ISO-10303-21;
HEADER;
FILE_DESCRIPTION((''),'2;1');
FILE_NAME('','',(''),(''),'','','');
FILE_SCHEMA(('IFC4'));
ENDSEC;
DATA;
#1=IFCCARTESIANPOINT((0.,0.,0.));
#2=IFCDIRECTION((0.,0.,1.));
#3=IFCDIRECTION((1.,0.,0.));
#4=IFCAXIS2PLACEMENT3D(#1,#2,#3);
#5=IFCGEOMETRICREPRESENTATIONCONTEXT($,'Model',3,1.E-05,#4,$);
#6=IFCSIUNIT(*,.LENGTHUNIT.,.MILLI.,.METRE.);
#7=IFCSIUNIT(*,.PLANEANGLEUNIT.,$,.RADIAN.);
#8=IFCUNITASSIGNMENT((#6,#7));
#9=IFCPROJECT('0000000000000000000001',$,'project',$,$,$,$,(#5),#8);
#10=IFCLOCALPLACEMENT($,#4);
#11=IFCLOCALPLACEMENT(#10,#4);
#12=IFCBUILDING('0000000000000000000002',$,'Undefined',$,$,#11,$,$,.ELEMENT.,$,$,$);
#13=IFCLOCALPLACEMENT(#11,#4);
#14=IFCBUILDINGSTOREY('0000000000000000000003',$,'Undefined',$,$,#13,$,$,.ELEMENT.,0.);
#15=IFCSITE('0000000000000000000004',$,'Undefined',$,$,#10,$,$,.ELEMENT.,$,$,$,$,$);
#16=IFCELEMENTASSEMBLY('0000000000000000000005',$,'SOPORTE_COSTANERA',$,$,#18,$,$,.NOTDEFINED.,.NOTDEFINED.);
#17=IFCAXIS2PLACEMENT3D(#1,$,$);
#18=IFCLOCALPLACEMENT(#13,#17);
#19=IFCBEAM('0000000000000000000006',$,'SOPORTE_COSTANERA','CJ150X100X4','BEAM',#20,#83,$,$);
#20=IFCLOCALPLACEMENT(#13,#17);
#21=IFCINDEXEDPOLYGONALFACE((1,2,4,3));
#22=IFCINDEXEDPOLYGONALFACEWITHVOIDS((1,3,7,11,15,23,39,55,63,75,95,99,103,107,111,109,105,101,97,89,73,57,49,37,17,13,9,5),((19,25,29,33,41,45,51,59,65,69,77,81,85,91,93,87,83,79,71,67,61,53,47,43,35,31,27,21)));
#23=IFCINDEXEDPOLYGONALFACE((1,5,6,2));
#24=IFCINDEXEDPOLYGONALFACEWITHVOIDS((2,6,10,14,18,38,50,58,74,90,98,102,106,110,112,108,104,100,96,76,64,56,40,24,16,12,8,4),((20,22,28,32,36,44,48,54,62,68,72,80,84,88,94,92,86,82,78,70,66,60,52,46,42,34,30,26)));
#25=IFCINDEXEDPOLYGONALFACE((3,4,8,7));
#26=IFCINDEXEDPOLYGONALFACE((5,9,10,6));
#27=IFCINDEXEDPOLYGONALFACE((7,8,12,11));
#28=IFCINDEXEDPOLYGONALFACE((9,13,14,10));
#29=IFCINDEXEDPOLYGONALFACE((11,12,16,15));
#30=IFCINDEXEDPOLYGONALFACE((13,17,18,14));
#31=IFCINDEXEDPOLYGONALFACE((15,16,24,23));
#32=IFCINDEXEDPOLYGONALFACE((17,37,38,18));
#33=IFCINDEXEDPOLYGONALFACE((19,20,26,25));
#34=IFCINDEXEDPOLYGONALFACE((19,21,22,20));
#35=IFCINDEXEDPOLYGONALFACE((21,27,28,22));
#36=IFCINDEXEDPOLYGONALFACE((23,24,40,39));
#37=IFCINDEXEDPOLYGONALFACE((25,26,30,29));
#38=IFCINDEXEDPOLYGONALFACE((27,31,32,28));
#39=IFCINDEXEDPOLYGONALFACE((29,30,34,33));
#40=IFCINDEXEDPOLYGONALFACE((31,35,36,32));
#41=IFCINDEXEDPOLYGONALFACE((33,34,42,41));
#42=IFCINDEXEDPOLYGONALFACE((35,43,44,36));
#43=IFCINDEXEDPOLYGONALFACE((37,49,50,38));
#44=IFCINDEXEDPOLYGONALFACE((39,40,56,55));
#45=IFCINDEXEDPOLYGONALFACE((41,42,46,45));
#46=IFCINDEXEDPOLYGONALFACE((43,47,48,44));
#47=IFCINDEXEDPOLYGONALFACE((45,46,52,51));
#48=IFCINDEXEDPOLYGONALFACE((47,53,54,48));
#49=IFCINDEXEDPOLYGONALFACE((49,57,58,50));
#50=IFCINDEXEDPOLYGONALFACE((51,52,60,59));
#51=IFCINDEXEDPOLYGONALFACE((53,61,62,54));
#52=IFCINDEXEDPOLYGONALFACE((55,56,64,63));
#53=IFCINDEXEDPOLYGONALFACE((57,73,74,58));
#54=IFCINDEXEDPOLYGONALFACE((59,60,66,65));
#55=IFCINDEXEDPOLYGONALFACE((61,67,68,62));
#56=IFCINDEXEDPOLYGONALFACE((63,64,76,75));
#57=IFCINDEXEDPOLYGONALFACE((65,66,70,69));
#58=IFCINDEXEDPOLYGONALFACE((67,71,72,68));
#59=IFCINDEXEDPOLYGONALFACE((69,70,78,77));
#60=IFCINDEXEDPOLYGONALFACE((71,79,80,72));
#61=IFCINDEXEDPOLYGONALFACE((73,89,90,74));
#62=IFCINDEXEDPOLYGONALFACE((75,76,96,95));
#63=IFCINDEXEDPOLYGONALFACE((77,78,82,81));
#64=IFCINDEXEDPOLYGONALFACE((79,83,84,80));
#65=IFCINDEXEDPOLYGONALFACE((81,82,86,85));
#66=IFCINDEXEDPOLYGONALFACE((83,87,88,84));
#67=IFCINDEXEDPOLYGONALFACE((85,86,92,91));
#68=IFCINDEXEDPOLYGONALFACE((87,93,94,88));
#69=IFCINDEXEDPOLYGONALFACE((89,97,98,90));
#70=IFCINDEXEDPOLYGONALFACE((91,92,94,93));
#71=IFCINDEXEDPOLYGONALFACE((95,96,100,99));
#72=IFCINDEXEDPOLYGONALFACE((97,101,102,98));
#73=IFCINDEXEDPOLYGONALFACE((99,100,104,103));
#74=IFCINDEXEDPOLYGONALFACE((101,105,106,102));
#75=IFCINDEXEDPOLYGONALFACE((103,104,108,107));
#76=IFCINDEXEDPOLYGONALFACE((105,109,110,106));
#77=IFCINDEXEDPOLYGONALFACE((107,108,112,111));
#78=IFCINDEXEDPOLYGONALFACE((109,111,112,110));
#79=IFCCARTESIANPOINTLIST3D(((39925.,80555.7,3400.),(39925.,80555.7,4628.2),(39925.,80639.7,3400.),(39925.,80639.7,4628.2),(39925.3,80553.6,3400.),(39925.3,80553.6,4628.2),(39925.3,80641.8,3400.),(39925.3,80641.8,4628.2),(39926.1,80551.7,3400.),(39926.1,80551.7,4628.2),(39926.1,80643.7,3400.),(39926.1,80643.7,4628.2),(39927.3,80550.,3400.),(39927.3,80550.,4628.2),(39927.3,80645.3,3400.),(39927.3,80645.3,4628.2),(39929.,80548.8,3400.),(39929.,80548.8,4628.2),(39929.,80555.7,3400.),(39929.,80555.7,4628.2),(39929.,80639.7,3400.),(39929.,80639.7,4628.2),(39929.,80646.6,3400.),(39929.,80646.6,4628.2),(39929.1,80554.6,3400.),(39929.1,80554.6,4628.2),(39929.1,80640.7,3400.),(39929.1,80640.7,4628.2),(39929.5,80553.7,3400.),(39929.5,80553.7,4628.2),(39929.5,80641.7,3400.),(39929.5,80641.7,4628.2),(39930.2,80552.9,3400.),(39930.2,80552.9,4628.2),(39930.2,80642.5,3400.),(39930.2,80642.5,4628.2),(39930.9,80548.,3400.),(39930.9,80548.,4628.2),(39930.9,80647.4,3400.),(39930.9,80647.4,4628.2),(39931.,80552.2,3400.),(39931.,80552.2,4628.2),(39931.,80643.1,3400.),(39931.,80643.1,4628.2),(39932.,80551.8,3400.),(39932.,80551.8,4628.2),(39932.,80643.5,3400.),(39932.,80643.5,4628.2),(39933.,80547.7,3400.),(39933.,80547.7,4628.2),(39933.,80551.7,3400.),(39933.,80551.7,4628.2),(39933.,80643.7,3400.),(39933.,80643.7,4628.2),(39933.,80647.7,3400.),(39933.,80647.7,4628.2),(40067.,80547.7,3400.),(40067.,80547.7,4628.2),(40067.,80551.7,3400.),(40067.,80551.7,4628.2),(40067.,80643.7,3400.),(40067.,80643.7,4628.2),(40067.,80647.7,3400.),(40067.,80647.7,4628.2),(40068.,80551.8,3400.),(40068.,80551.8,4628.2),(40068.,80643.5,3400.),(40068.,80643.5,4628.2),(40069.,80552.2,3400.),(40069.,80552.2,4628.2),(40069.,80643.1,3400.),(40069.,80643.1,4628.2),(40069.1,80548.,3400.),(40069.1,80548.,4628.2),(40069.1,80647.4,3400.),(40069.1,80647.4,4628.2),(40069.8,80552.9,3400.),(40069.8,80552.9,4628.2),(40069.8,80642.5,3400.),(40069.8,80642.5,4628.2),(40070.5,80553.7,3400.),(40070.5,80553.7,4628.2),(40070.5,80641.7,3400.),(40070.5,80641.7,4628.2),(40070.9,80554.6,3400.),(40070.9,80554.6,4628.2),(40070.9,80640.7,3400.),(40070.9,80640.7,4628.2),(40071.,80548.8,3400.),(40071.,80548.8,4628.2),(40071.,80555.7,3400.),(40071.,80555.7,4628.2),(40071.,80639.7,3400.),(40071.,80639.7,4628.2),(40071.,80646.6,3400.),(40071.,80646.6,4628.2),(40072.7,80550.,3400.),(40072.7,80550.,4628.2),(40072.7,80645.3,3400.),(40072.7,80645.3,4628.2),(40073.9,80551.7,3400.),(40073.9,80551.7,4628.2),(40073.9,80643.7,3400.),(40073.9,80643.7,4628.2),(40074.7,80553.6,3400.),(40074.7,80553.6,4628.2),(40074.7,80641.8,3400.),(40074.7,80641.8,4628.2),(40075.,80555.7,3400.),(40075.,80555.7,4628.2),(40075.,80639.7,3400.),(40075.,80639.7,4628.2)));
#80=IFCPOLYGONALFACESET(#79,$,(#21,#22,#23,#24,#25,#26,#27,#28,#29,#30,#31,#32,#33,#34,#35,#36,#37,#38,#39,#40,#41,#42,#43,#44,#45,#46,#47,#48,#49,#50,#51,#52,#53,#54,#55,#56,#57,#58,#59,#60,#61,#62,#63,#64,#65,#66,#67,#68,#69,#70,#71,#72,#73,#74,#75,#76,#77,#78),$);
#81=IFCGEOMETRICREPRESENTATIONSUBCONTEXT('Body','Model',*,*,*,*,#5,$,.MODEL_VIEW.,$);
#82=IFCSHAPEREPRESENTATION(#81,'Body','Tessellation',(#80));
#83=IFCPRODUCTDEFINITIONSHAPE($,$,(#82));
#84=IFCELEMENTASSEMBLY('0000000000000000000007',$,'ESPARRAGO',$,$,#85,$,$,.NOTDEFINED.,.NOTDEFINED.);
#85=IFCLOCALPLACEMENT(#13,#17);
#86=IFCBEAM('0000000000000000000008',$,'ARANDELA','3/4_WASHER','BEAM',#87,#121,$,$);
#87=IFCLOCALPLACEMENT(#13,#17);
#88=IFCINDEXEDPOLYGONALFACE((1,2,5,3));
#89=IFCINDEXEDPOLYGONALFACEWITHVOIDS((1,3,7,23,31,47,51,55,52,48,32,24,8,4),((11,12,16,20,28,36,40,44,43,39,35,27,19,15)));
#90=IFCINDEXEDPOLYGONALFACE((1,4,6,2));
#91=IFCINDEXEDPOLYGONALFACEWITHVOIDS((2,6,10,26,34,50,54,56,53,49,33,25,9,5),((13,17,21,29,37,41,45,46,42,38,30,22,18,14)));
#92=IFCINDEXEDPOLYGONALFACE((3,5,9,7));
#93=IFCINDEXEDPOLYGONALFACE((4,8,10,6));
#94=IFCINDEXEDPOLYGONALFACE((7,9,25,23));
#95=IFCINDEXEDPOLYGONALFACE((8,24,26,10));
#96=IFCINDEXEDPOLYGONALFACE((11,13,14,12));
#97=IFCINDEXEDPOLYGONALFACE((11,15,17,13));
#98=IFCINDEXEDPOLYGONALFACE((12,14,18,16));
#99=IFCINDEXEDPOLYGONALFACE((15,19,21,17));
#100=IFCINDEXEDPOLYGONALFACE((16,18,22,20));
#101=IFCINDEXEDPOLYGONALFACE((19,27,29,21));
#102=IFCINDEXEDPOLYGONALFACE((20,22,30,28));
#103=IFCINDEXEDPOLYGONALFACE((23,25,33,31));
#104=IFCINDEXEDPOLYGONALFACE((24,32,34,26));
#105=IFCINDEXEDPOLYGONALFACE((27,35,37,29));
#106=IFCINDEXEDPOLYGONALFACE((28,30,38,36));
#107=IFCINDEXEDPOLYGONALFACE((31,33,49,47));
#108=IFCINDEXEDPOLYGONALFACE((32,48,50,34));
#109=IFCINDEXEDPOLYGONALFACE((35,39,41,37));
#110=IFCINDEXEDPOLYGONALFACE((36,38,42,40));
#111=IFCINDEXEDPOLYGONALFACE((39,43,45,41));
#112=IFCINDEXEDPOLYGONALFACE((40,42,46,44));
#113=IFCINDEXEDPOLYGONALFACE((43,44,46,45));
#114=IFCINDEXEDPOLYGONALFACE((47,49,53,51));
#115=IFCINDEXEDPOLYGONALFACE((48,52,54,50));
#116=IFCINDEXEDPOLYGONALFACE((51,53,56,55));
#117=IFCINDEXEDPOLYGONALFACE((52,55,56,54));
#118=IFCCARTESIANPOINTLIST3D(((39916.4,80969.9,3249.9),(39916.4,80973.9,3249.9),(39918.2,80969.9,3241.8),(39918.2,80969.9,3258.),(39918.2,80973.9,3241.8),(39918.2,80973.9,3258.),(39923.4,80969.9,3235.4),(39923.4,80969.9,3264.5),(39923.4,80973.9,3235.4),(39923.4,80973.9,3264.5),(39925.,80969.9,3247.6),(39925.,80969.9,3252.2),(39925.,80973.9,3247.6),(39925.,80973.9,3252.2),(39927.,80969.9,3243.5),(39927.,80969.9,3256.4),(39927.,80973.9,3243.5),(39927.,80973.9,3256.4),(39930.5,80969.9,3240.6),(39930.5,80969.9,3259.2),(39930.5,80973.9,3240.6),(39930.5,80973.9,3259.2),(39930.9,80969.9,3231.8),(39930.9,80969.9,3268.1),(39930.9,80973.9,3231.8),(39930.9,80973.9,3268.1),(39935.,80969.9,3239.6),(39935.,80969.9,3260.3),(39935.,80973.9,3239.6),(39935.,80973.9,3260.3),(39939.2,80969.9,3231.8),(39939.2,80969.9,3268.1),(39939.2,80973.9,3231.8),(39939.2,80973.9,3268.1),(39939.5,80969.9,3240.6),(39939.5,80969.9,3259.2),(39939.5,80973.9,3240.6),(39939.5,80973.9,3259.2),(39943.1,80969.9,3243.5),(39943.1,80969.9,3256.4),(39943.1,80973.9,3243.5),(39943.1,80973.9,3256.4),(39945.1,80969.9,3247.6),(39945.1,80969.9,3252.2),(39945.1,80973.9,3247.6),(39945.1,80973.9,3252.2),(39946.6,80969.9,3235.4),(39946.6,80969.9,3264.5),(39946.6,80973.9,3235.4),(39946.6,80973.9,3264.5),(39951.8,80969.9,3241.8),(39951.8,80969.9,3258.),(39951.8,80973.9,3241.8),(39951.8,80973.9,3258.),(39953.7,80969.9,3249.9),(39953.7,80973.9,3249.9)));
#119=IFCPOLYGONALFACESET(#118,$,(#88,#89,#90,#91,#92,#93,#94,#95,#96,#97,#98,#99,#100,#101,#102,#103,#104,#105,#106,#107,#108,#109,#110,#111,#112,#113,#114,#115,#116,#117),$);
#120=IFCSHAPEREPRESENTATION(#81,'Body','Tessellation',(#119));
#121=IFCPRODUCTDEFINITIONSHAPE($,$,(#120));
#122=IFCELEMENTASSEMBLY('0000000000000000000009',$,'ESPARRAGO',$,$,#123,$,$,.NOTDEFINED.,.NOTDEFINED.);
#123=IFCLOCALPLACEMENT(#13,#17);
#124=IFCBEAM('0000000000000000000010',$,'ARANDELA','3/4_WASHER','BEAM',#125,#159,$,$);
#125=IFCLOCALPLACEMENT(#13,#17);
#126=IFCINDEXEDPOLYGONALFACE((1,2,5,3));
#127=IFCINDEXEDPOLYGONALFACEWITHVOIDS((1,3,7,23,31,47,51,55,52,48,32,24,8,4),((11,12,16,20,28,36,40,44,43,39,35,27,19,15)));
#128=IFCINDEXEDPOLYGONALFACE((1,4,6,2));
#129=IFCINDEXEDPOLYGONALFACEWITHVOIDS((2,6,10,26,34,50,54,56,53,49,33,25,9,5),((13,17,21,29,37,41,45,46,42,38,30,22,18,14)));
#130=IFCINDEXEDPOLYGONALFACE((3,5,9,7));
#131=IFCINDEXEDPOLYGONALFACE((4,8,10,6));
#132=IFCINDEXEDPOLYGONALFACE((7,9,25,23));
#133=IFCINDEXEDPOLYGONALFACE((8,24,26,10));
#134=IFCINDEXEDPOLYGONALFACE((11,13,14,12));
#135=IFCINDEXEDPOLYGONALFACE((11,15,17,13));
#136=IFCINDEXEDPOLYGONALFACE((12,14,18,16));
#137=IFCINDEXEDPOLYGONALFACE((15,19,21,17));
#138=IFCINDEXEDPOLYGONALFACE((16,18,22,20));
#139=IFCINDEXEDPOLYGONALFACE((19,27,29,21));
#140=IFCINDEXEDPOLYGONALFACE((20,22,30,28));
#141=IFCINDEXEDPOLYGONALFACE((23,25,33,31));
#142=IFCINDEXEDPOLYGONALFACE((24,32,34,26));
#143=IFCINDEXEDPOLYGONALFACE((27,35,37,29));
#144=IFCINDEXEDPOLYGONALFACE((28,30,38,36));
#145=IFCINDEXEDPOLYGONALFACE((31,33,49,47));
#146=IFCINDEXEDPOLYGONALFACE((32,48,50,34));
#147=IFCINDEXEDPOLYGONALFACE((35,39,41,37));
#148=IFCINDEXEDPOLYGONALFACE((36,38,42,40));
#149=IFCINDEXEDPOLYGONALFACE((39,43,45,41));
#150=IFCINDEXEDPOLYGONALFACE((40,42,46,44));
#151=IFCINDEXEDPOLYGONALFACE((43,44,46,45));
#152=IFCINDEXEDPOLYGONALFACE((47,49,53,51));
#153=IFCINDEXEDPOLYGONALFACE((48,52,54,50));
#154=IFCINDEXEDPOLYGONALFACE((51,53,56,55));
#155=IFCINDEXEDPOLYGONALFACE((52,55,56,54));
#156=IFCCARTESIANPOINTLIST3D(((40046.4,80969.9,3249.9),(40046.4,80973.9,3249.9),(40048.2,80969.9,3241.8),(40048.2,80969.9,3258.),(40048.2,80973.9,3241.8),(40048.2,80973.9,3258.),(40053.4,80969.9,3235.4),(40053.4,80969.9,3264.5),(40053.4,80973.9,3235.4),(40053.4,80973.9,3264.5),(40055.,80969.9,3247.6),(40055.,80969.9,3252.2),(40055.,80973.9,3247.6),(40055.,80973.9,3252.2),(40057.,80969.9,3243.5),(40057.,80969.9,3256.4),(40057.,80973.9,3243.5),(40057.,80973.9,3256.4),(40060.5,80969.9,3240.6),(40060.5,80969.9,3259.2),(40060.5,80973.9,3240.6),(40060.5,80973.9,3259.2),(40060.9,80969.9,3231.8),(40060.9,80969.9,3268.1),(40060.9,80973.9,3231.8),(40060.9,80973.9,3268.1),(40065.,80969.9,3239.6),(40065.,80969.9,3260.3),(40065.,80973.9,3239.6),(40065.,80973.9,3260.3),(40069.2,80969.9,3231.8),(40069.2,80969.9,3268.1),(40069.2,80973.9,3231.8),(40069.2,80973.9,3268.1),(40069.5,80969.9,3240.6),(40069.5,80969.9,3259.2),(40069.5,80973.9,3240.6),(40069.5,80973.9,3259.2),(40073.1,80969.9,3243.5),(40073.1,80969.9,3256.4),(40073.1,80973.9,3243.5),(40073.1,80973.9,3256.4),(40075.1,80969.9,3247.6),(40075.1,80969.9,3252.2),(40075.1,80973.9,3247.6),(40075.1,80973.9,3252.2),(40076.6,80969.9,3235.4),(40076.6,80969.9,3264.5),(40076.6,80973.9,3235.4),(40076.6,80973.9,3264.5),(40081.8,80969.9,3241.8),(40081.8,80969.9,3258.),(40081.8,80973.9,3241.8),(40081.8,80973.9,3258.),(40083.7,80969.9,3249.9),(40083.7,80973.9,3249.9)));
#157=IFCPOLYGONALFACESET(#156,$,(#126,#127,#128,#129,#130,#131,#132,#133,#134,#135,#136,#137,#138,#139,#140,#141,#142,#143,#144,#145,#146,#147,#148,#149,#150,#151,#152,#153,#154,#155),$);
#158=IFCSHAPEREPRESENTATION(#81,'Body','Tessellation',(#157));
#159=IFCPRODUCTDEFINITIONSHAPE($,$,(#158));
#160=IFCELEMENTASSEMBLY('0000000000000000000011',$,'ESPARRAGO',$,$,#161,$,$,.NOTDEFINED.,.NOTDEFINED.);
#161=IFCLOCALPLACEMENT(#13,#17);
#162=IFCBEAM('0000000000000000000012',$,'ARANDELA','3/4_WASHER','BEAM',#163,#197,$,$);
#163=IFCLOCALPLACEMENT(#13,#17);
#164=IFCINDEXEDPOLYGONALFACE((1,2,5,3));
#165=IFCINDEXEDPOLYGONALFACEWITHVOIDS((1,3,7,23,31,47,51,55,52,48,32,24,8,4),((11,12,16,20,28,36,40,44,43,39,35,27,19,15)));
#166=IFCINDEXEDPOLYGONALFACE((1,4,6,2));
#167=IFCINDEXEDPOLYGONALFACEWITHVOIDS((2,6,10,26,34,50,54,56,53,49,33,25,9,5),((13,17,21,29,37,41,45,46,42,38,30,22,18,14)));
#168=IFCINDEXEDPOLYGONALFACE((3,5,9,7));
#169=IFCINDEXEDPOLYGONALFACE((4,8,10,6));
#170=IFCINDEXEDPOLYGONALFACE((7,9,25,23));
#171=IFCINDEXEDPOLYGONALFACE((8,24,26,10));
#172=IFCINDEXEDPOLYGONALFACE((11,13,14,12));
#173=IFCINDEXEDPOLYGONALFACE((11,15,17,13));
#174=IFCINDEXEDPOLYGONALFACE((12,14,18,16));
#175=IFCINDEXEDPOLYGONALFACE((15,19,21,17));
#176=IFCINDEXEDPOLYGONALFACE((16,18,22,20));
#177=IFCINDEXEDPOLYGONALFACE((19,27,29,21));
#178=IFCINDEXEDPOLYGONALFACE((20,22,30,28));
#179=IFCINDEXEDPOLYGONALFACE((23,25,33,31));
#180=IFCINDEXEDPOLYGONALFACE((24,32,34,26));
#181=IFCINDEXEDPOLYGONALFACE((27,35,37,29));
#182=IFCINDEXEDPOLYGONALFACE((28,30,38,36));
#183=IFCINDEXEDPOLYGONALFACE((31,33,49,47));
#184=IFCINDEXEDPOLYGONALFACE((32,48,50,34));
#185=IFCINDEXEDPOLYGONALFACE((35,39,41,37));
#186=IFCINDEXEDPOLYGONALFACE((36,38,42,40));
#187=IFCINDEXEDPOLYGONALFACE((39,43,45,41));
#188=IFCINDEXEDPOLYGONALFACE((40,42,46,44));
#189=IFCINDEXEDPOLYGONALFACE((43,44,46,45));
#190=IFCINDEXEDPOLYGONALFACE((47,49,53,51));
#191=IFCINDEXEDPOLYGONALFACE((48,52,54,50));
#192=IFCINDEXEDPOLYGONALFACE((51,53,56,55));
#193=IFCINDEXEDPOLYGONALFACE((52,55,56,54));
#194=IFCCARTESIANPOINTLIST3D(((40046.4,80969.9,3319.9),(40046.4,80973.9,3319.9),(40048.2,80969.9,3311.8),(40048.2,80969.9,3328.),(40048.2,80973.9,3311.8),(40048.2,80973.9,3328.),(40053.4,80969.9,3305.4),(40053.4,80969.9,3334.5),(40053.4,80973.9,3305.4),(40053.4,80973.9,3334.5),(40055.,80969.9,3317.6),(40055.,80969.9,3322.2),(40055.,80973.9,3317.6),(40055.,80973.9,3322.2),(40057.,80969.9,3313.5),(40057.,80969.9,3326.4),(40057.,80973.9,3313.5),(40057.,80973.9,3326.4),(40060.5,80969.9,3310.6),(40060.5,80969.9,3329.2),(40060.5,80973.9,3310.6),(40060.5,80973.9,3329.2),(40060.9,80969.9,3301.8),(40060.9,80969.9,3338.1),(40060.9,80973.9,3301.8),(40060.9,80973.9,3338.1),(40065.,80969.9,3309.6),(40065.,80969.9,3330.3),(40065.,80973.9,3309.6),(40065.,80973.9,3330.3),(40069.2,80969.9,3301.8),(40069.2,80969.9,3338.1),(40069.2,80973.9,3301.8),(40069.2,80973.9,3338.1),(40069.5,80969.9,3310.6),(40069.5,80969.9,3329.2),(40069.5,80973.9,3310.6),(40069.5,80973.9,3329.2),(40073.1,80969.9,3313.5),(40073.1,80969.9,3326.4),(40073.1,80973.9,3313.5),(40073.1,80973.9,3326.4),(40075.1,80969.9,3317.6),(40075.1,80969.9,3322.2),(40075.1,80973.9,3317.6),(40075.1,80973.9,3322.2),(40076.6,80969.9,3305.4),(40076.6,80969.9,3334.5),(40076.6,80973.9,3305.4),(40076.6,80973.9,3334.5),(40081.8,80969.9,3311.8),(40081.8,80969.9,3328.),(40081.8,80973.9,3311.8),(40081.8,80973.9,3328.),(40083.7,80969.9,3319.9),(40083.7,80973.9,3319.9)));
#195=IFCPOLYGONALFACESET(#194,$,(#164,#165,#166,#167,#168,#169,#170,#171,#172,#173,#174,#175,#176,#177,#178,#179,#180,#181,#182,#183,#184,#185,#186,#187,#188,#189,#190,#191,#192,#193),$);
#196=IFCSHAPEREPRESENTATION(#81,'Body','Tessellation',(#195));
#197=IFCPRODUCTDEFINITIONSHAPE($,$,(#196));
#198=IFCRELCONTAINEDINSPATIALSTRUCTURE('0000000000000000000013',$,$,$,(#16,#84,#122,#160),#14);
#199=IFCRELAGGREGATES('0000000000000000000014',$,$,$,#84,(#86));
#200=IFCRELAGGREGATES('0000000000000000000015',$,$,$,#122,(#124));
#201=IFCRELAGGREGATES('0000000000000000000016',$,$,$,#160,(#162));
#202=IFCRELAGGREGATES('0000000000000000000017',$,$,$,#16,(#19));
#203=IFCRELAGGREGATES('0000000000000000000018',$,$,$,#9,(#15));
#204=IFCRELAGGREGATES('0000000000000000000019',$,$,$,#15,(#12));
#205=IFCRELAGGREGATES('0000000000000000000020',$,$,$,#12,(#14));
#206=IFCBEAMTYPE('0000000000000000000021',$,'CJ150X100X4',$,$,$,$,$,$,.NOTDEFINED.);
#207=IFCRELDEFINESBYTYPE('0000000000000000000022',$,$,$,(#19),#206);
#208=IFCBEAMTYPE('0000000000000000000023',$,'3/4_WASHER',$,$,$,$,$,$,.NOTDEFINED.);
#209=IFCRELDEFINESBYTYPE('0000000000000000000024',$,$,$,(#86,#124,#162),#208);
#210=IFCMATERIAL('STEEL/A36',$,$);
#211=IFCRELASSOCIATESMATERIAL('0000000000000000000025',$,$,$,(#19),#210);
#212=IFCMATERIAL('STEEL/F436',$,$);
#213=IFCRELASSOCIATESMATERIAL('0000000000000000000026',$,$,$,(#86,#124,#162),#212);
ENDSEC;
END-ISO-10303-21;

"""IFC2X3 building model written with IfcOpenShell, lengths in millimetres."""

from ifc_helpers import new_model, si_unit, frame, origin_with_axes, origin_2d_with_axis, place, context, subcontext, project, spatial, polyline, hollow_rectangle, outline, extrude, material, type_object, element, aggregate, save


model = new_model("IFC2X3")

# Units and contexts
model_context = context("Model", 3, precision=1e-05, world=origin_with_axes())
body_context = subcontext(model_context, "Body", "Model", "MODEL_VIEW")
ifc_project = project(units=[si_unit("LENGTHUNIT", "METRE", prefix="MILLI"), si_unit("PLANEANGLEUNIT", "RADIAN")], contexts=[model_context])

# Site, building, storey
site_placement = place(None, origin_with_axes())
site = spatial("IfcSite", under=ifc_project, at=site_placement, Name="Undefined", CompositionType="ELEMENT")
building_placement = place(site_placement, origin_with_axes())
building = spatial("IfcBuilding", under=site, at=building_placement, Name="Undefined", CompositionType="ELEMENT")
storey_placement = place(building_placement, origin_with_axes())
storey = spatial("IfcBuildingStorey", under=building, at=storey_placement, Name="Undefined", CompositionType="ELEMENT", Elevation=0.0)

# Element assemblies, beams
assembly_1_placement = place(storey_placement, origin_with_axes())
assembly_1 = element("IfcElementAssembly", 1, at=assembly_1_placement, inside=storey, Name="SOPORTE_COSTANERA", AssemblyPlace="NOTDEFINED", PredefinedType="NOTDEFINED")
ifc_material_1 = material(Name="STEEL/A36")
beam_type_1 = type_object("IfcBeamType", Name="CJ150X100X4", PredefinedType="NOTDEFINED")
beam_1_placement = place(assembly_1_placement, frame((40000.0, 80597.7, 4628.2), z_axis=(-1.0, 0.0, 0.0), x_axis=(0.0, 0.0, -1.0)))
beam_1 = element("IfcBeam", 2, at=beam_1_placement, type_object=beam_type_1, material=ifc_material_1, Name="SOPORTE_COSTANERA", Description="CJ150X100X4", ObjectType="BEAM", context=body_context, shape_type="SweptSolid", body=[
    extrude(hollow_rectangle(XDim=100.0, YDim=150.0, WallThickness=4.0, InnerFilletRadius=4.0, OuterFilletRadius=8.0, at=origin_2d_with_axis()), frame((1228.2, 0.0, 0.0), z_axis=(-1.0, 0.0, 0.0), x_axis=(0.0, -1.0, 0.0)), (0.0, 0.0, 1.0), 1228.2),
])
assembly_2_placement = place(storey_placement, origin_with_axes())
assembly_2 = element("IfcElementAssembly", 3, at=assembly_2_placement, inside=storey, Name="ESPARRAGO", AssemblyPlace="NOTDEFINED", PredefinedType="NOTDEFINED")
ifc_material_2 = material(Name="STEEL/F436")
beam_type_2 = type_object("IfcBeamType", Name="3/4_WASHER", PredefinedType="NOTDEFINED")
beam_2_placement = place(assembly_2_placement, frame((39935.0, 80969.9, 3249.9), z_axis=(0.0, 0.000086, 1.0), x_axis=(0.000015, 1.0, -0.000086)))
beam_2 = element("IfcBeam", 4, at=beam_2_placement, type_object=beam_type_2, material=ifc_material_2, Name="ARANDELA", Description="3/4_WASHER", ObjectType="BEAM", context=body_context, shape_type="SweptSolid", body=[
    extrude(outline(polyline([(-16.8, 8.1), (-11.6, 14.6), (-4.2, 18.2), (4.2, 18.2), (11.6, 14.6), (16.8, 8.1), (18.6, 0.0), (16.8, -8.1), (11.6, -14.6), (4.2, -18.2), (-4.2, -18.2), (-11.6, -14.6), (-16.8, -8.1), (-18.6, 0.0), (-16.8, 8.1)]), holes=[polyline([(8.1, 6.4), (4.5, 9.3), (0.0, 10.3), (-4.5, 9.3), (-8.1, 6.4), (-10.1, 2.3), (-10.1, -2.3), (-8.1, -6.4), (-4.5, -9.3), (0.0, -10.3), (4.5, -9.3), (8.1, -6.4), (10.1, -2.3), (10.1, 2.3), (8.1, 6.4)])]), frame((4.0, 0.0, 0.0), z_axis=(-1.0, 0.0, 0.0), x_axis=(0.0, -1.0, 0.0)), (0.0, 0.0, 1.0), 4.0),
])
assembly_3_placement = place(storey_placement, origin_with_axes())
assembly_3 = element("IfcElementAssembly", 5, at=assembly_3_placement, inside=storey, Name="ESPARRAGO", AssemblyPlace="NOTDEFINED", PredefinedType="NOTDEFINED")
beam_3_placement = place(assembly_3_placement, frame((40065.0, 80969.9, 3249.9), z_axis=(0.0, 0.000086, 1.0), x_axis=(0.000015, 1.0, -0.000086)))
beam_3 = element("IfcBeam", 6, at=beam_3_placement, type_object=beam_type_2, material=ifc_material_2, Name="ARANDELA", Description="3/4_WASHER", ObjectType="BEAM", context=body_context, shape_type="SweptSolid", body=[
    extrude(outline(polyline([(-16.8, 8.1), (-11.6, 14.6), (-4.2, 18.2), (4.2, 18.2), (11.6, 14.6), (16.8, 8.1), (18.6, 0.0), (16.8, -8.1), (11.6, -14.6), (4.2, -18.2), (-4.2, -18.2), (-11.6, -14.6), (-16.8, -8.1), (-18.6, 0.0), (-16.8, 8.1)]), holes=[polyline([(8.1, 6.4), (4.5, 9.3), (0.0, 10.3), (-4.5, 9.3), (-8.1, 6.4), (-10.1, 2.3), (-10.1, -2.3), (-8.1, -6.4), (-4.5, -9.3), (0.0, -10.3), (4.5, -9.3), (8.1, -6.4), (10.1, -2.3), (10.1, 2.3), (8.1, 6.4)])]), frame((4.0, 0.0, 0.0), z_axis=(-1.0, 0.0, 0.0), x_axis=(0.0, -1.0, 0.0)), (0.0, 0.0, 1.0), 4.0),
])
assembly_4_placement = place(storey_placement, origin_with_axes())
assembly_4 = element("IfcElementAssembly", 7, at=assembly_4_placement, inside=storey, Name="ESPARRAGO", AssemblyPlace="NOTDEFINED", PredefinedType="NOTDEFINED")
beam_4_placement = place(assembly_4_placement, frame((40065.0, 80969.9, 3319.9), z_axis=(0.0, 0.000086, 1.0), x_axis=(0.000015, 1.0, -0.000086)))
beam_4 = element("IfcBeam", 8, at=beam_4_placement, type_object=beam_type_2, material=ifc_material_2, Name="ARANDELA", Description="3/4_WASHER", ObjectType="BEAM", context=body_context, shape_type="SweptSolid", body=[
    extrude(outline(polyline([(-16.8, 8.1), (-11.6, 14.6), (-4.2, 18.2), (4.2, 18.2), (11.6, 14.6), (16.8, 8.1), (18.6, 0.0), (16.8, -8.1), (11.6, -14.6), (4.2, -18.2), (-4.2, -18.2), (-11.6, -14.6), (-16.8, -8.1), (-18.6, 0.0), (-16.8, 8.1)]), holes=[polyline([(8.1, 6.4), (4.5, 9.3), (0.0, 10.3), (-4.5, 9.3), (-8.1, 6.4), (-10.1, 2.3), (-10.1, -2.3), (-8.1, -6.4), (-4.5, -9.3), (0.0, -10.3), (4.5, -9.3), (8.1, -6.4), (10.1, -2.3), (10.1, 2.3), (8.1, 6.4)])]), frame((4.0, 0.0, 0.0), z_axis=(-1.0, 0.0, 0.0), x_axis=(0.0, -1.0, 0.0)), (0.0, 0.0, 1.0), 4.0),
])

aggregate(assembly_2, [beam_2])
aggregate(assembly_3, [beam_3])
aggregate(assembly_4, [beam_4])

aggregate(assembly_1, [beam_1])

save(model, "model.ifc")
